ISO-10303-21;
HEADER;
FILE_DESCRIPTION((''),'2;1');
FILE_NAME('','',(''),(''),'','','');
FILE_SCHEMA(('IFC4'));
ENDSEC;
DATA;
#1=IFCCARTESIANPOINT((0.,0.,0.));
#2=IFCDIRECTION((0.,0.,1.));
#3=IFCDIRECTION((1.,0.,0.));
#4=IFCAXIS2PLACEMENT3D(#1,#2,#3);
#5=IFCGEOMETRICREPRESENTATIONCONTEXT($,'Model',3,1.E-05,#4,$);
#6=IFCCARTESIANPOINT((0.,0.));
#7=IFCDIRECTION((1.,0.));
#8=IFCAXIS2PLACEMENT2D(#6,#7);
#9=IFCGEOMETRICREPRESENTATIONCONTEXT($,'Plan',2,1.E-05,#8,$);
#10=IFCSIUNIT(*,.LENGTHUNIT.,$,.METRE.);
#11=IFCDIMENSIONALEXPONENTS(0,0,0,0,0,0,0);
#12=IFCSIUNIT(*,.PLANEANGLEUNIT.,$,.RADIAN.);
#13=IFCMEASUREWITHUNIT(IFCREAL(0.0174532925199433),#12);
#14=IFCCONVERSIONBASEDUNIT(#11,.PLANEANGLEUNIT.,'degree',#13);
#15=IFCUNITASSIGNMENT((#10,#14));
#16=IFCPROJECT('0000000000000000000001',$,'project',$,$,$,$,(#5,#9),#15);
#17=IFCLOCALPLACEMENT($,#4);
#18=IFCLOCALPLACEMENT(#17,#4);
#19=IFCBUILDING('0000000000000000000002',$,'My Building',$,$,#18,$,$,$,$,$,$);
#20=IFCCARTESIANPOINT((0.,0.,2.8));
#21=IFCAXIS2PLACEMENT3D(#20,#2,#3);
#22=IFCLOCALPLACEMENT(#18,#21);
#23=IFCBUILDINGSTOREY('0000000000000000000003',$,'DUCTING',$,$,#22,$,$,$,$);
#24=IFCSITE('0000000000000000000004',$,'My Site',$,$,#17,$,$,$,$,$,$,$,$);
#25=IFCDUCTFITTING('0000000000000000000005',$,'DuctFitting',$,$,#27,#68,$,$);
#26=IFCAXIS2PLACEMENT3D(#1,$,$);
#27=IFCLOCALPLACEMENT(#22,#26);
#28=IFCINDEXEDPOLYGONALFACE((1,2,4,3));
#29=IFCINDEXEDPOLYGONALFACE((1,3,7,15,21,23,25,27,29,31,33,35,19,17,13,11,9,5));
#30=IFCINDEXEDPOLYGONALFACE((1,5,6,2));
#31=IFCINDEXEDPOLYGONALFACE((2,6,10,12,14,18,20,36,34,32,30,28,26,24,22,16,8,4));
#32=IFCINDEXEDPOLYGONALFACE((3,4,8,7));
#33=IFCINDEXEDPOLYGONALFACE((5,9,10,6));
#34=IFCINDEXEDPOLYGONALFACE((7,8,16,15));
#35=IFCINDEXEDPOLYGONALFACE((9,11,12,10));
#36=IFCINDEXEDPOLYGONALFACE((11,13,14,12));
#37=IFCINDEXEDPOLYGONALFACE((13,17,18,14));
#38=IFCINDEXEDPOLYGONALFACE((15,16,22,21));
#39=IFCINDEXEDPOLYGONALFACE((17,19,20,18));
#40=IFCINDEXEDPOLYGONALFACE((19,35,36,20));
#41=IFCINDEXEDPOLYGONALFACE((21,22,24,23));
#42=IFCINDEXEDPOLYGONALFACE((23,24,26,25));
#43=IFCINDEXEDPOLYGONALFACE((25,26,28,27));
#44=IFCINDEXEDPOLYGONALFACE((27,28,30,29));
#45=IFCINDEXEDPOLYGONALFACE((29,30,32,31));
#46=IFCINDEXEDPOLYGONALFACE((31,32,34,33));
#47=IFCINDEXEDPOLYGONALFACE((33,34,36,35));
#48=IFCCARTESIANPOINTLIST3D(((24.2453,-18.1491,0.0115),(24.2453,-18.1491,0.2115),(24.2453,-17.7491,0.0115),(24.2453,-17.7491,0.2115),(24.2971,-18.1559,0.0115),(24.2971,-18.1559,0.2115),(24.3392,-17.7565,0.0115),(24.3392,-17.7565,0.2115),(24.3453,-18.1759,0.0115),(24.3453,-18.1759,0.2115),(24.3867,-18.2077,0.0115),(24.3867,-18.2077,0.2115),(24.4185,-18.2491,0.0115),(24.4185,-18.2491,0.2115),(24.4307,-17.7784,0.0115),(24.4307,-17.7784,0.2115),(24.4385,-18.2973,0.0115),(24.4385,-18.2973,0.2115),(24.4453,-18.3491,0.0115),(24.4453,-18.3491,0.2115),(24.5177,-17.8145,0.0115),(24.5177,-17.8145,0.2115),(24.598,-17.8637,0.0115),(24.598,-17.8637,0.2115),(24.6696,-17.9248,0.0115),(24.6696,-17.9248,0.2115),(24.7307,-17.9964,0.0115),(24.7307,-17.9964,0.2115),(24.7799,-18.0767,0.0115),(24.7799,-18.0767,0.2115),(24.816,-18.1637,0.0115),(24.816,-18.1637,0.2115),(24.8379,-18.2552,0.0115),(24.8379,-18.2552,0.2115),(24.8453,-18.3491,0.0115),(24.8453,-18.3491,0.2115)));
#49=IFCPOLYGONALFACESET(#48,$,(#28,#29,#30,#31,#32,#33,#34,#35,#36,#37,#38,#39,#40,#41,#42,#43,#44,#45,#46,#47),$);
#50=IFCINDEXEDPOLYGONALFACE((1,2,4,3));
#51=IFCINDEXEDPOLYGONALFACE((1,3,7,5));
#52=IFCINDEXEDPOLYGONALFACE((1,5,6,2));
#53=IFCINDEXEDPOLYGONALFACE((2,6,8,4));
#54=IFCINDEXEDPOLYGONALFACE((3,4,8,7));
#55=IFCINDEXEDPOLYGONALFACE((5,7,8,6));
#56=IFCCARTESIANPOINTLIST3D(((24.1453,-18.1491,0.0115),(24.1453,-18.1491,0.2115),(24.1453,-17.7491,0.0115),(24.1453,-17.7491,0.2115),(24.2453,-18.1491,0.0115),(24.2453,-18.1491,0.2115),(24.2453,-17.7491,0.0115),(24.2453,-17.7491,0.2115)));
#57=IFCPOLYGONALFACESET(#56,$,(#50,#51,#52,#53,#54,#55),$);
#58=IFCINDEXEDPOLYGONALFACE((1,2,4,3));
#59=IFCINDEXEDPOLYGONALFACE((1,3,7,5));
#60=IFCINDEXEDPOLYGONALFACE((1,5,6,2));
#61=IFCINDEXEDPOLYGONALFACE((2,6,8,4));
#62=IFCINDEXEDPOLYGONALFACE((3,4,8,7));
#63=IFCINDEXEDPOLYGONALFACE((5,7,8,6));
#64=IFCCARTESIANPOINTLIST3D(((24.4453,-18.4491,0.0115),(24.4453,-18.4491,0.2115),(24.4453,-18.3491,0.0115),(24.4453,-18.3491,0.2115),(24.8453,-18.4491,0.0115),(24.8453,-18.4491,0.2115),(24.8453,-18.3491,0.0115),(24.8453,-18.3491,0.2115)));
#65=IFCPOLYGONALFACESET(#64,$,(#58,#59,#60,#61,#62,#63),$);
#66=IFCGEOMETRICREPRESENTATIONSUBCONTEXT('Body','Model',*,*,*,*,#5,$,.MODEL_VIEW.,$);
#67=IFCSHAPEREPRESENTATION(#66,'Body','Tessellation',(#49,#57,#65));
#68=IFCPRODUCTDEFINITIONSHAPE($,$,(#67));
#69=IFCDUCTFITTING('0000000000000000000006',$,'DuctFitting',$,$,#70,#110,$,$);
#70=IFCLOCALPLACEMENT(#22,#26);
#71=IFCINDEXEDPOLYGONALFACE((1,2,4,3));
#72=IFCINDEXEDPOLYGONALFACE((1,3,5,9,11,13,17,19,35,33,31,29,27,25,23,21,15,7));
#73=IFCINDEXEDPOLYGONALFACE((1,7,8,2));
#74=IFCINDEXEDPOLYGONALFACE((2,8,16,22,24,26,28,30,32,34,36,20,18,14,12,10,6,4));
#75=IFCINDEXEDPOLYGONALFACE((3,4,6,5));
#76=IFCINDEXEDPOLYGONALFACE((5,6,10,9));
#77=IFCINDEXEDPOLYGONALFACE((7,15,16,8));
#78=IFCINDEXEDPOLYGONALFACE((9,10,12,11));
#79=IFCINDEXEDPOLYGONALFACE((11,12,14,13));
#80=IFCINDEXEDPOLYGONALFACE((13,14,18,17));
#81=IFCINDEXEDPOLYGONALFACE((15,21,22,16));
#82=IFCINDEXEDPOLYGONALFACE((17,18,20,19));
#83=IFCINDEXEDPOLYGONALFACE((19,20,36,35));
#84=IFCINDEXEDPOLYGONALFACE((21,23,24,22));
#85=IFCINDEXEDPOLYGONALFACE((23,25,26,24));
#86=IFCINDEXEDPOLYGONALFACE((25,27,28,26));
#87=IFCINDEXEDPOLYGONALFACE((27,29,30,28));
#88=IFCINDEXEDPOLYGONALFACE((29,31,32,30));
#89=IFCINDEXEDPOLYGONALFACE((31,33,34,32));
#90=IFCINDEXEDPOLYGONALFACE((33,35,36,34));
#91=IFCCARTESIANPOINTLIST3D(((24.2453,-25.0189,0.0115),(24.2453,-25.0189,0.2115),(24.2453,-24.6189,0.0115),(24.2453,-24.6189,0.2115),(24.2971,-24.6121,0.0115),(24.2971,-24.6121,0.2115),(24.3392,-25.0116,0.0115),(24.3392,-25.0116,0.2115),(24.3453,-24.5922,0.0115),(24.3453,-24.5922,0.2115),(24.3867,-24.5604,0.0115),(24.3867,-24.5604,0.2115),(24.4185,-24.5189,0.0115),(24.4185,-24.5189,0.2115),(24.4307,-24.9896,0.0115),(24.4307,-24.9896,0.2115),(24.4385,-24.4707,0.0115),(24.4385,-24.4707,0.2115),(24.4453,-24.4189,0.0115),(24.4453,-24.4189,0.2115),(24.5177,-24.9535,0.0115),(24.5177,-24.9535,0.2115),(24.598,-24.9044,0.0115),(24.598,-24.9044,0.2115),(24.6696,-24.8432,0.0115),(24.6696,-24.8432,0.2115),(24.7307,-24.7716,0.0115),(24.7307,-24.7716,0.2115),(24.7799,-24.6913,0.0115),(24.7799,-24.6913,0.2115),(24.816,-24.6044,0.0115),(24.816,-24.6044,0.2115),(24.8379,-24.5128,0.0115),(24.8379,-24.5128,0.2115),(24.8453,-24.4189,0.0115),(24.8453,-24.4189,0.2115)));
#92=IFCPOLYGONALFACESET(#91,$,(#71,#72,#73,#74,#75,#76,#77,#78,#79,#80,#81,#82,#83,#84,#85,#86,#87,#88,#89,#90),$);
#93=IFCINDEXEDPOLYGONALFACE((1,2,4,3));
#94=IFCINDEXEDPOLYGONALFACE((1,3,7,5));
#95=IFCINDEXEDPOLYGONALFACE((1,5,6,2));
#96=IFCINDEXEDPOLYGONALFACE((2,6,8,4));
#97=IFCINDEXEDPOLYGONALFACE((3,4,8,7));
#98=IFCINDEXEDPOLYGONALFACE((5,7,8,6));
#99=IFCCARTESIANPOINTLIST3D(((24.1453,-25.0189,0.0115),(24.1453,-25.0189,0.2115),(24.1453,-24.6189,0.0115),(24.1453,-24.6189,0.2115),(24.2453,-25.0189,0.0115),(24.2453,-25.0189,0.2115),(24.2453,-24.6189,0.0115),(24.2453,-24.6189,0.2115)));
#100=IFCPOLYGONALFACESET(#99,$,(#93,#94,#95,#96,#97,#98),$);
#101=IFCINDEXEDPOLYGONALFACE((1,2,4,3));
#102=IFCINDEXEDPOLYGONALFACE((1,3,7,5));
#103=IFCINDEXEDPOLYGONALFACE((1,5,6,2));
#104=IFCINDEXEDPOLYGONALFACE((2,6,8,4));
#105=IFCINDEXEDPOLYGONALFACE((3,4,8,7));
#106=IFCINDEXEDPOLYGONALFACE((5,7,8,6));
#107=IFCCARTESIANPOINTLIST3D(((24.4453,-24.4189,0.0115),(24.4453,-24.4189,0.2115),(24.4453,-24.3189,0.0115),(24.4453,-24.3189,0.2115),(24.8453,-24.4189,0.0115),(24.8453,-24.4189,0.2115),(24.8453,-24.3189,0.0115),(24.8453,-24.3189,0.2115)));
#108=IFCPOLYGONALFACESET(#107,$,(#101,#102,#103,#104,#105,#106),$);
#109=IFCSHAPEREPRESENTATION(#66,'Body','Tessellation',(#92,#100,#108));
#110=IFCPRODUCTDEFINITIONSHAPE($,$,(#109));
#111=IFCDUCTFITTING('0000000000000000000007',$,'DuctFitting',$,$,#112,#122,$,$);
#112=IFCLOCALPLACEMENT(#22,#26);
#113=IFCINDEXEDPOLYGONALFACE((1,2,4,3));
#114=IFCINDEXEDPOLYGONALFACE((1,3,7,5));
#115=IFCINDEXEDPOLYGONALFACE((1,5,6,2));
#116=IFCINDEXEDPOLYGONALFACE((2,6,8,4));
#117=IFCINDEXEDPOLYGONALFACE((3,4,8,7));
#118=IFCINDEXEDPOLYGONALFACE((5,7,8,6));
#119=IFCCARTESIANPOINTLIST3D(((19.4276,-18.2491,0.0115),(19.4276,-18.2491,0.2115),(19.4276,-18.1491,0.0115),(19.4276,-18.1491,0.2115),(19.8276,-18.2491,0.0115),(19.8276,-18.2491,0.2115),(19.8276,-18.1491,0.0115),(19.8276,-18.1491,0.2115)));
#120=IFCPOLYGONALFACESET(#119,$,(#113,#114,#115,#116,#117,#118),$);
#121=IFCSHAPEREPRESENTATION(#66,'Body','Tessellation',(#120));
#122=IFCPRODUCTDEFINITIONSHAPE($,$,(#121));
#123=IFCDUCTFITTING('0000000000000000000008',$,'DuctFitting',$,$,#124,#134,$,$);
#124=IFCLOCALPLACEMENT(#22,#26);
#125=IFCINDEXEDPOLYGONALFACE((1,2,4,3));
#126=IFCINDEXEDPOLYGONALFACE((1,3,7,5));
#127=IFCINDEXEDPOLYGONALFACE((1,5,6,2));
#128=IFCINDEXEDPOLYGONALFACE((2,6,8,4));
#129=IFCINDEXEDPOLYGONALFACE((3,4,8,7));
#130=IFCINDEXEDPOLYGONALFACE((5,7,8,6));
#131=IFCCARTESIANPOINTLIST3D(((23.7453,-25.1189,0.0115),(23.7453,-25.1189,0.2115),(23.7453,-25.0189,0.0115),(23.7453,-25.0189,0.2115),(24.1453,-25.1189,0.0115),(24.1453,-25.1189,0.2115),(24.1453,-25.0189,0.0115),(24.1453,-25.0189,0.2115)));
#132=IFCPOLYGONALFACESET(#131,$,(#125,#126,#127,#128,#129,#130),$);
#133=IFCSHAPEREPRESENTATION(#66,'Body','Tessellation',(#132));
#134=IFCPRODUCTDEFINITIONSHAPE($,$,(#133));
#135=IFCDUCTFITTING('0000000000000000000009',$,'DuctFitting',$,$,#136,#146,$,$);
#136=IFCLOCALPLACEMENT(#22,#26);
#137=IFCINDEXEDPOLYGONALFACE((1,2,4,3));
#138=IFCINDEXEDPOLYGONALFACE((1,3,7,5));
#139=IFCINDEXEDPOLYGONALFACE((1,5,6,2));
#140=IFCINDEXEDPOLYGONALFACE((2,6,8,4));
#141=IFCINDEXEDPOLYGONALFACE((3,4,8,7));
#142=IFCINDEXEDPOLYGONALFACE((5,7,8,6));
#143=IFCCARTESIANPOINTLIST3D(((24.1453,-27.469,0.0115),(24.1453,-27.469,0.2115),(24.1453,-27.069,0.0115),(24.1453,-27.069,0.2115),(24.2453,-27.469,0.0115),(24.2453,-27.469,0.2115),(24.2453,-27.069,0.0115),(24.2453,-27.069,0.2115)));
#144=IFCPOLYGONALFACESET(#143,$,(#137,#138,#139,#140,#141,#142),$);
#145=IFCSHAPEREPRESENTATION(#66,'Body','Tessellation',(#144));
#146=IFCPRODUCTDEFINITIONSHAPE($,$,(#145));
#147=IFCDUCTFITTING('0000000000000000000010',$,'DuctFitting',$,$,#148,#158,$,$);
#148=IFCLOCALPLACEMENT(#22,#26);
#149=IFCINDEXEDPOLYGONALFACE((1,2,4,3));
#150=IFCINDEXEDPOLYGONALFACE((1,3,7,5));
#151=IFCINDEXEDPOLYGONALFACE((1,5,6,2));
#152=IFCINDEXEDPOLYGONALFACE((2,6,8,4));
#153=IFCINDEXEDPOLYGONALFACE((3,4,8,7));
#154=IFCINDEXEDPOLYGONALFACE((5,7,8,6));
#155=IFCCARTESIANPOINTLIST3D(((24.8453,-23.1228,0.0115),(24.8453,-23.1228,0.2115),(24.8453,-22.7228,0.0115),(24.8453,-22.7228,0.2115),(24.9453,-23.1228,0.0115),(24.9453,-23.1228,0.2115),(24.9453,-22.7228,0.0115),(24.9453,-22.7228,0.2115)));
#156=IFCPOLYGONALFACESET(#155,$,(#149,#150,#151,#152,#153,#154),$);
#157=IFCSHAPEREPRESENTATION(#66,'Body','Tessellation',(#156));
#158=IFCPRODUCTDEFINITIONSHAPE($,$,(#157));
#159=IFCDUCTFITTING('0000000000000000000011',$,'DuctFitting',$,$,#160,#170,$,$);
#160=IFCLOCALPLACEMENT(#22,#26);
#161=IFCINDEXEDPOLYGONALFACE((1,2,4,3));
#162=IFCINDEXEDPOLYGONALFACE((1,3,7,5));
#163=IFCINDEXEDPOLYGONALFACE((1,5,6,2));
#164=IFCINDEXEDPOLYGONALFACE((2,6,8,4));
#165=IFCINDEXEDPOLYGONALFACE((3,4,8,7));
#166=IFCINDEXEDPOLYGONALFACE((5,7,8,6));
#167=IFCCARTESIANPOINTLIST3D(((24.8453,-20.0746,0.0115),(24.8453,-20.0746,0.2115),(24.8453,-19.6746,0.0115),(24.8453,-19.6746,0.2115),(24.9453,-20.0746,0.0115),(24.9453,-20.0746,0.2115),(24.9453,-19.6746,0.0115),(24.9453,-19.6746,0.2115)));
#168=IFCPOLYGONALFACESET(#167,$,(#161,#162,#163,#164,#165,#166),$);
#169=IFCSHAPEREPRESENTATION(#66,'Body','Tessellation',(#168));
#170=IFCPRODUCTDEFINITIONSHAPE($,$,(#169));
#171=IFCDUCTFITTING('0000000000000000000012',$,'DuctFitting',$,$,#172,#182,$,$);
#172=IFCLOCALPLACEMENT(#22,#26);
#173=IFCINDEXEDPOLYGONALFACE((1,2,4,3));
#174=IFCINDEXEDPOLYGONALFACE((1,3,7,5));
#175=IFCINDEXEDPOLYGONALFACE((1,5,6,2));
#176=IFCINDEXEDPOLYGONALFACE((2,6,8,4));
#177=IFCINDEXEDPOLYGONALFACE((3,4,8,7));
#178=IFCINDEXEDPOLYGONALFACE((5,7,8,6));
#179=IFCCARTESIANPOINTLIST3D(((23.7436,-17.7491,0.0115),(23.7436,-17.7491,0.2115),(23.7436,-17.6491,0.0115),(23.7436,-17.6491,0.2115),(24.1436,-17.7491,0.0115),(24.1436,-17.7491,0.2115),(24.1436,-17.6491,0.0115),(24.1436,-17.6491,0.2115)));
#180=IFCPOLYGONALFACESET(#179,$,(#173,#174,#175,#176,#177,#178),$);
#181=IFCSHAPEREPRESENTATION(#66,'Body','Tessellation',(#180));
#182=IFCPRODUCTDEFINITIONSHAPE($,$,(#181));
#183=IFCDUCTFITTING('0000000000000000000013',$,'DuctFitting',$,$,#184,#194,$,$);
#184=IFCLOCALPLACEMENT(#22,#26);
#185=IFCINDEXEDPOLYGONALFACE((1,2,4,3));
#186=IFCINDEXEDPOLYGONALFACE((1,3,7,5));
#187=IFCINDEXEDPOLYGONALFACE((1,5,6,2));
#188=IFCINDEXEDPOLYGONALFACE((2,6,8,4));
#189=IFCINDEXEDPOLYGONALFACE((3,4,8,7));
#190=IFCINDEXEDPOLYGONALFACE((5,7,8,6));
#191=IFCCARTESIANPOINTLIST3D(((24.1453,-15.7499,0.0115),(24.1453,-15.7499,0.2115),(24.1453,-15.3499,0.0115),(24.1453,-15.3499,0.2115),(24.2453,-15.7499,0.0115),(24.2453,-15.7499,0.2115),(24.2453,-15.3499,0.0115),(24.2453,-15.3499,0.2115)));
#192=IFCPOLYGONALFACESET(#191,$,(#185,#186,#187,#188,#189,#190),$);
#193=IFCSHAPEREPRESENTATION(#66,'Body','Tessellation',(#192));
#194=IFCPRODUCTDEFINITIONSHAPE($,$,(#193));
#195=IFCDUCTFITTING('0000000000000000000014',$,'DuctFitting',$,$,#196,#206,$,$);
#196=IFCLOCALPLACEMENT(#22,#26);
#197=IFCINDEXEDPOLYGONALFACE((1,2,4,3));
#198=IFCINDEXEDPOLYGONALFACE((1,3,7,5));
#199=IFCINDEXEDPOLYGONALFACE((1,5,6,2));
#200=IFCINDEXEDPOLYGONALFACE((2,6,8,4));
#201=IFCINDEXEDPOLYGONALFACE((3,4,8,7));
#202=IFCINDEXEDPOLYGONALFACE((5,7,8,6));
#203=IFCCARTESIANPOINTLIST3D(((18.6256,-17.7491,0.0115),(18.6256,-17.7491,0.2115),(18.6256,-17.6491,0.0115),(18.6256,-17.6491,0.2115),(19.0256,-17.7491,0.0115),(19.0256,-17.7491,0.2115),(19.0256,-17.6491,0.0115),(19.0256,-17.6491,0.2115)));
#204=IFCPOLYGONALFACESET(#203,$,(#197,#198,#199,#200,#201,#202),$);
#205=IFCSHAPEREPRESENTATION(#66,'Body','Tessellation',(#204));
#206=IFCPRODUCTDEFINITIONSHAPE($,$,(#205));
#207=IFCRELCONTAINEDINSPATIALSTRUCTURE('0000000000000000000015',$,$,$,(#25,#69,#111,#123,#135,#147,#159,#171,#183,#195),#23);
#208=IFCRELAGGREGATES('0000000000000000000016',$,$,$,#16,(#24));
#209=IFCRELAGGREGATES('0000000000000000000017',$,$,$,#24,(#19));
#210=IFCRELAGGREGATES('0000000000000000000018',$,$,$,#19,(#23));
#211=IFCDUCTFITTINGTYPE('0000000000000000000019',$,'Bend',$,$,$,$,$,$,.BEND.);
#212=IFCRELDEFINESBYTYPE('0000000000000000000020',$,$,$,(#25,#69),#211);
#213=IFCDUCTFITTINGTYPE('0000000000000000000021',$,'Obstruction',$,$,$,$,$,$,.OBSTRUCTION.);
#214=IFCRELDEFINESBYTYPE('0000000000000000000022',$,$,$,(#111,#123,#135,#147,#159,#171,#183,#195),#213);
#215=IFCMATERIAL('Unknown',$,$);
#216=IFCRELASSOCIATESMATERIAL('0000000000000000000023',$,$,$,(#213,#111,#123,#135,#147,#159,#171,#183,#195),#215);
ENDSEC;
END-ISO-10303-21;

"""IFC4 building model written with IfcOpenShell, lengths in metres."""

from ifc_helpers import new_model, entity, si_unit, converted_unit, frame, origin_with_axes, origin_2d_with_axis, place, context, subcontext, project, spatial, line, arc, indexed_curve, rectangle, outline, extrude, source, transform, mapped, material, material_profile, profile_set, profile_usage, type_object, type_shapes, element, save


model = new_model("IFC4")

# Units and contexts
model_context = context("Model", 3, precision=1e-05, world=origin_with_axes())
plan_context = context("Plan", 2, precision=1e-05, world=origin_2d_with_axis())
body_context = subcontext(model_context, "Body", "Model", "MODEL_VIEW")
ifc_project = project(units=[si_unit("LENGTHUNIT", "METRE"), converted_unit("PLANEANGLEUNIT", "degree", entity("IfcReal", 0.0174532925199433), si_unit("PLANEANGLEUNIT", "RADIAN"), dimensions=[0, 0, 0, 0, 0, 0, 0])], contexts=[model_context, plan_context])

# Site, building, storey
site_placement = place(None, origin_with_axes())
site = spatial("IfcSite", under=ifc_project, at=site_placement, Name="My Site")
building_placement = place(site_placement, origin_with_axes())
building = spatial("IfcBuilding", under=site, at=building_placement, Name="My Building")
storey_placement = place(building_placement, frame((0.0, 0.0, 2.8), z_axis=(0.0, 0.0, 1.0), x_axis=(1.0, 0.0, 0.0)))
storey = spatial("IfcBuildingStorey", under=building, at=storey_placement, Name="DUCTING")

# Shared definitions
ifc_material = material(Name="Unknown")

# Duct fittings
duct_fitting_type_1 = type_object("IfcDuctFittingType", Name="Bend", PredefinedType="BEND")
shared_shape = source(origin_with_axes(), body_context, "Body", "SweptSolid", [
    extrude(outline(indexed_curve([(-0.2, 0.0), (-0.2586, 0.1414), (-0.4, 0.2), (-0.4, 0.6), (0.0243, 0.4243), (0.2, 0.0)], segments=[arc(1, 2, 3), line(3, 4), arc(4, 5, 6), line(6, 1)])), frame((0.0, -0.1, 0.1), z_axis=(0.0, -1.0, 0.0), x_axis=(1.0, 0.0, 0.0)), (0.0, 0.0, -1.0), 0.2),
    extrude(rectangle(XDim=0.4, YDim=0.2), origin_with_axes(), (0.0, 0.0, 1.0), 0.1),
    extrude(rectangle(XDim=0.4, YDim=0.2), frame((-0.4, 0.0, 0.5), z_axis=(-1.0, 0.0, 0.000001), x_axis=(-0.000001, 0.0, -1.0)), (0.0, 0.0, 1.0), 0.1),
])
type_shapes(duct_fitting_type_1, [shared_shape])
for number, where, z_axis, x_axis, name in (
    (1, (24.1453, -17.9491, 0.1115), (1.0, -0.000001, 0.000001), (0.000001, 1.0, 0.0), "DuctFitting"),
    (2, (24.1453, -24.8189, 0.1115), (1.0, -0.000001, 0.000001), (-0.000001, -1.0, 0.0), "DuctFitting"),
):
    element("IfcDuctFitting", number, at=place(storey_placement, frame(where, z_axis=z_axis, x_axis=x_axis)), inside=storey, type_object=duct_fitting_type_1, Name=name, context=body_context, shape_type="MappedRepresentation", body=[
        mapped(shared_shape, transform((0.0, 0.0, 0.0), x_axis=(1.0, 0.0, 0.0), y_axis=(0.0, 1.0, 0.0), z_axis=(0.0, 0.0, 1.0), scale=1.0)),
    ])
ifc_material_profile_1 = material_profile(ifc_material, rectangle(XDim=0.4, YDim=0.2))
ifc_profile_set_1 = profile_set([ifc_material_profile_1])
ifc_profile_usage_1 = profile_usage(ifc_profile_set_1, cardinal=5)
duct_fitting_type_2 = type_object("IfcDuctFittingType", Name="Obstruction", PredefinedType="OBSTRUCTION", material=ifc_profile_set_1)
duct_fitting_1_placement = place(storey_placement, frame((19.6276, -18.1491, 0.1115), z_axis=(0.000001, -1.0, 0.0), x_axis=(1.0, 0.000001, 0.0)))
element("IfcDuctFitting", 3, at=duct_fitting_1_placement, inside=storey, type_object=duct_fitting_type_2, material=ifc_profile_usage_1, Name="DuctFitting", context=body_context, shape_type="SweptSolid", body=[
    extrude(rectangle(XDim=0.4, YDim=0.2), origin_with_axes(), (0.0, 0.0, 1.0), 0.1),
])
ifc_profile_usage_2 = profile_usage(ifc_profile_set_1, cardinal=5)
duct_fitting_2_placement = place(storey_placement, frame((23.9453, -25.0189, 0.1115), z_axis=(0.0, -1.0, 0.0), x_axis=(1.0, 0.0, 0.0)))
element("IfcDuctFitting", 4, at=duct_fitting_2_placement, inside=storey, type_object=duct_fitting_type_2, material=ifc_profile_usage_2, Name="DuctFitting", context=body_context, shape_type="SweptSolid", body=[
    extrude(rectangle(XDim=0.4, YDim=0.2), origin_with_axes(), (0.0, 0.0, 1.0), 0.1),
])
ifc_profile_usage_3 = profile_usage(ifc_profile_set_1, cardinal=5)
duct_fitting_3_placement = place(storey_placement, frame((24.1453, -27.269, 0.1115), z_axis=(1.0, 0.0, 0.0), x_axis=(0.0, 1.0, 0.0)))
element("IfcDuctFitting", 5, at=duct_fitting_3_placement, inside=storey, type_object=duct_fitting_type_2, material=ifc_profile_usage_3, Name="DuctFitting", context=body_context, shape_type="SweptSolid", body=[
    extrude(rectangle(XDim=0.4, YDim=0.2), origin_with_axes(), (0.0, 0.0, 1.0), 0.1),
])
ifc_profile_usage_4 = profile_usage(ifc_profile_set_1, cardinal=5)
duct_fitting_4_placement = place(storey_placement, frame((24.8453, -22.9228, 0.1115), z_axis=(1.0, 0.0, 0.0), x_axis=(0.0, 1.0, 0.0)))
element("IfcDuctFitting", 6, at=duct_fitting_4_placement, inside=storey, type_object=duct_fitting_type_2, material=ifc_profile_usage_4, Name="DuctFitting", context=body_context, shape_type="SweptSolid", body=[
    extrude(rectangle(XDim=0.4, YDim=0.2), origin_with_axes(), (0.0, 0.0, 1.0), 0.1),
])
ifc_profile_usage_5 = profile_usage(ifc_profile_set_1, cardinal=5)
duct_fitting_5_placement = place(storey_placement, frame((24.8453, -19.8746, 0.1115), z_axis=(1.0, 0.0, 0.0), x_axis=(0.0, 1.0, 0.0)))
element("IfcDuctFitting", 7, at=duct_fitting_5_placement, inside=storey, type_object=duct_fitting_type_2, material=ifc_profile_usage_5, Name="DuctFitting", context=body_context, shape_type="SweptSolid", body=[
    extrude(rectangle(XDim=0.4, YDim=0.2), origin_with_axes(), (0.0, 0.0, 1.0), 0.1),
])
ifc_profile_usage_6 = profile_usage(ifc_profile_set_1, cardinal=5)
duct_fitting_6_placement = place(storey_placement, frame((23.9436, -17.6491, 0.1115), z_axis=(0.0, -1.0, 0.0), x_axis=(1.0, 0.0, 0.0)))
element("IfcDuctFitting", 8, at=duct_fitting_6_placement, inside=storey, type_object=duct_fitting_type_2, material=ifc_profile_usage_6, Name="DuctFitting", context=body_context, shape_type="SweptSolid", body=[
    extrude(rectangle(XDim=0.4, YDim=0.2), origin_with_axes(), (0.0, 0.0, 1.0), 0.1),
])
ifc_profile_usage_7 = profile_usage(ifc_profile_set_1, cardinal=5)
duct_fitting_7_placement = place(storey_placement, frame((24.1453, -15.5499, 0.1115), z_axis=(1.0, 0.0, 0.0), x_axis=(0.0, 1.0, 0.0)))
element("IfcDuctFitting", 9, at=duct_fitting_7_placement, inside=storey, type_object=duct_fitting_type_2, material=ifc_profile_usage_7, Name="DuctFitting", context=body_context, shape_type="SweptSolid", body=[
    extrude(rectangle(XDim=0.4, YDim=0.2), origin_with_axes(), (0.0, 0.0, 1.0), 0.1),
])
ifc_profile_usage_8 = profile_usage(ifc_profile_set_1, cardinal=5)
duct_fitting_8_placement = place(storey_placement, frame((18.8256, -17.6491, 0.1115), z_axis=(0.0, -1.0, 0.0), x_axis=(1.0, 0.0, 0.0)))
element("IfcDuctFitting", 10, at=duct_fitting_8_placement, inside=storey, type_object=duct_fitting_type_2, material=ifc_profile_usage_8, Name="DuctFitting", context=body_context, shape_type="SweptSolid", body=[
    extrude(rectangle(XDim=0.4, YDim=0.2), origin_with_axes(), (0.0, 0.0, 1.0), 0.1),
])

save(model, "model.ifc")
